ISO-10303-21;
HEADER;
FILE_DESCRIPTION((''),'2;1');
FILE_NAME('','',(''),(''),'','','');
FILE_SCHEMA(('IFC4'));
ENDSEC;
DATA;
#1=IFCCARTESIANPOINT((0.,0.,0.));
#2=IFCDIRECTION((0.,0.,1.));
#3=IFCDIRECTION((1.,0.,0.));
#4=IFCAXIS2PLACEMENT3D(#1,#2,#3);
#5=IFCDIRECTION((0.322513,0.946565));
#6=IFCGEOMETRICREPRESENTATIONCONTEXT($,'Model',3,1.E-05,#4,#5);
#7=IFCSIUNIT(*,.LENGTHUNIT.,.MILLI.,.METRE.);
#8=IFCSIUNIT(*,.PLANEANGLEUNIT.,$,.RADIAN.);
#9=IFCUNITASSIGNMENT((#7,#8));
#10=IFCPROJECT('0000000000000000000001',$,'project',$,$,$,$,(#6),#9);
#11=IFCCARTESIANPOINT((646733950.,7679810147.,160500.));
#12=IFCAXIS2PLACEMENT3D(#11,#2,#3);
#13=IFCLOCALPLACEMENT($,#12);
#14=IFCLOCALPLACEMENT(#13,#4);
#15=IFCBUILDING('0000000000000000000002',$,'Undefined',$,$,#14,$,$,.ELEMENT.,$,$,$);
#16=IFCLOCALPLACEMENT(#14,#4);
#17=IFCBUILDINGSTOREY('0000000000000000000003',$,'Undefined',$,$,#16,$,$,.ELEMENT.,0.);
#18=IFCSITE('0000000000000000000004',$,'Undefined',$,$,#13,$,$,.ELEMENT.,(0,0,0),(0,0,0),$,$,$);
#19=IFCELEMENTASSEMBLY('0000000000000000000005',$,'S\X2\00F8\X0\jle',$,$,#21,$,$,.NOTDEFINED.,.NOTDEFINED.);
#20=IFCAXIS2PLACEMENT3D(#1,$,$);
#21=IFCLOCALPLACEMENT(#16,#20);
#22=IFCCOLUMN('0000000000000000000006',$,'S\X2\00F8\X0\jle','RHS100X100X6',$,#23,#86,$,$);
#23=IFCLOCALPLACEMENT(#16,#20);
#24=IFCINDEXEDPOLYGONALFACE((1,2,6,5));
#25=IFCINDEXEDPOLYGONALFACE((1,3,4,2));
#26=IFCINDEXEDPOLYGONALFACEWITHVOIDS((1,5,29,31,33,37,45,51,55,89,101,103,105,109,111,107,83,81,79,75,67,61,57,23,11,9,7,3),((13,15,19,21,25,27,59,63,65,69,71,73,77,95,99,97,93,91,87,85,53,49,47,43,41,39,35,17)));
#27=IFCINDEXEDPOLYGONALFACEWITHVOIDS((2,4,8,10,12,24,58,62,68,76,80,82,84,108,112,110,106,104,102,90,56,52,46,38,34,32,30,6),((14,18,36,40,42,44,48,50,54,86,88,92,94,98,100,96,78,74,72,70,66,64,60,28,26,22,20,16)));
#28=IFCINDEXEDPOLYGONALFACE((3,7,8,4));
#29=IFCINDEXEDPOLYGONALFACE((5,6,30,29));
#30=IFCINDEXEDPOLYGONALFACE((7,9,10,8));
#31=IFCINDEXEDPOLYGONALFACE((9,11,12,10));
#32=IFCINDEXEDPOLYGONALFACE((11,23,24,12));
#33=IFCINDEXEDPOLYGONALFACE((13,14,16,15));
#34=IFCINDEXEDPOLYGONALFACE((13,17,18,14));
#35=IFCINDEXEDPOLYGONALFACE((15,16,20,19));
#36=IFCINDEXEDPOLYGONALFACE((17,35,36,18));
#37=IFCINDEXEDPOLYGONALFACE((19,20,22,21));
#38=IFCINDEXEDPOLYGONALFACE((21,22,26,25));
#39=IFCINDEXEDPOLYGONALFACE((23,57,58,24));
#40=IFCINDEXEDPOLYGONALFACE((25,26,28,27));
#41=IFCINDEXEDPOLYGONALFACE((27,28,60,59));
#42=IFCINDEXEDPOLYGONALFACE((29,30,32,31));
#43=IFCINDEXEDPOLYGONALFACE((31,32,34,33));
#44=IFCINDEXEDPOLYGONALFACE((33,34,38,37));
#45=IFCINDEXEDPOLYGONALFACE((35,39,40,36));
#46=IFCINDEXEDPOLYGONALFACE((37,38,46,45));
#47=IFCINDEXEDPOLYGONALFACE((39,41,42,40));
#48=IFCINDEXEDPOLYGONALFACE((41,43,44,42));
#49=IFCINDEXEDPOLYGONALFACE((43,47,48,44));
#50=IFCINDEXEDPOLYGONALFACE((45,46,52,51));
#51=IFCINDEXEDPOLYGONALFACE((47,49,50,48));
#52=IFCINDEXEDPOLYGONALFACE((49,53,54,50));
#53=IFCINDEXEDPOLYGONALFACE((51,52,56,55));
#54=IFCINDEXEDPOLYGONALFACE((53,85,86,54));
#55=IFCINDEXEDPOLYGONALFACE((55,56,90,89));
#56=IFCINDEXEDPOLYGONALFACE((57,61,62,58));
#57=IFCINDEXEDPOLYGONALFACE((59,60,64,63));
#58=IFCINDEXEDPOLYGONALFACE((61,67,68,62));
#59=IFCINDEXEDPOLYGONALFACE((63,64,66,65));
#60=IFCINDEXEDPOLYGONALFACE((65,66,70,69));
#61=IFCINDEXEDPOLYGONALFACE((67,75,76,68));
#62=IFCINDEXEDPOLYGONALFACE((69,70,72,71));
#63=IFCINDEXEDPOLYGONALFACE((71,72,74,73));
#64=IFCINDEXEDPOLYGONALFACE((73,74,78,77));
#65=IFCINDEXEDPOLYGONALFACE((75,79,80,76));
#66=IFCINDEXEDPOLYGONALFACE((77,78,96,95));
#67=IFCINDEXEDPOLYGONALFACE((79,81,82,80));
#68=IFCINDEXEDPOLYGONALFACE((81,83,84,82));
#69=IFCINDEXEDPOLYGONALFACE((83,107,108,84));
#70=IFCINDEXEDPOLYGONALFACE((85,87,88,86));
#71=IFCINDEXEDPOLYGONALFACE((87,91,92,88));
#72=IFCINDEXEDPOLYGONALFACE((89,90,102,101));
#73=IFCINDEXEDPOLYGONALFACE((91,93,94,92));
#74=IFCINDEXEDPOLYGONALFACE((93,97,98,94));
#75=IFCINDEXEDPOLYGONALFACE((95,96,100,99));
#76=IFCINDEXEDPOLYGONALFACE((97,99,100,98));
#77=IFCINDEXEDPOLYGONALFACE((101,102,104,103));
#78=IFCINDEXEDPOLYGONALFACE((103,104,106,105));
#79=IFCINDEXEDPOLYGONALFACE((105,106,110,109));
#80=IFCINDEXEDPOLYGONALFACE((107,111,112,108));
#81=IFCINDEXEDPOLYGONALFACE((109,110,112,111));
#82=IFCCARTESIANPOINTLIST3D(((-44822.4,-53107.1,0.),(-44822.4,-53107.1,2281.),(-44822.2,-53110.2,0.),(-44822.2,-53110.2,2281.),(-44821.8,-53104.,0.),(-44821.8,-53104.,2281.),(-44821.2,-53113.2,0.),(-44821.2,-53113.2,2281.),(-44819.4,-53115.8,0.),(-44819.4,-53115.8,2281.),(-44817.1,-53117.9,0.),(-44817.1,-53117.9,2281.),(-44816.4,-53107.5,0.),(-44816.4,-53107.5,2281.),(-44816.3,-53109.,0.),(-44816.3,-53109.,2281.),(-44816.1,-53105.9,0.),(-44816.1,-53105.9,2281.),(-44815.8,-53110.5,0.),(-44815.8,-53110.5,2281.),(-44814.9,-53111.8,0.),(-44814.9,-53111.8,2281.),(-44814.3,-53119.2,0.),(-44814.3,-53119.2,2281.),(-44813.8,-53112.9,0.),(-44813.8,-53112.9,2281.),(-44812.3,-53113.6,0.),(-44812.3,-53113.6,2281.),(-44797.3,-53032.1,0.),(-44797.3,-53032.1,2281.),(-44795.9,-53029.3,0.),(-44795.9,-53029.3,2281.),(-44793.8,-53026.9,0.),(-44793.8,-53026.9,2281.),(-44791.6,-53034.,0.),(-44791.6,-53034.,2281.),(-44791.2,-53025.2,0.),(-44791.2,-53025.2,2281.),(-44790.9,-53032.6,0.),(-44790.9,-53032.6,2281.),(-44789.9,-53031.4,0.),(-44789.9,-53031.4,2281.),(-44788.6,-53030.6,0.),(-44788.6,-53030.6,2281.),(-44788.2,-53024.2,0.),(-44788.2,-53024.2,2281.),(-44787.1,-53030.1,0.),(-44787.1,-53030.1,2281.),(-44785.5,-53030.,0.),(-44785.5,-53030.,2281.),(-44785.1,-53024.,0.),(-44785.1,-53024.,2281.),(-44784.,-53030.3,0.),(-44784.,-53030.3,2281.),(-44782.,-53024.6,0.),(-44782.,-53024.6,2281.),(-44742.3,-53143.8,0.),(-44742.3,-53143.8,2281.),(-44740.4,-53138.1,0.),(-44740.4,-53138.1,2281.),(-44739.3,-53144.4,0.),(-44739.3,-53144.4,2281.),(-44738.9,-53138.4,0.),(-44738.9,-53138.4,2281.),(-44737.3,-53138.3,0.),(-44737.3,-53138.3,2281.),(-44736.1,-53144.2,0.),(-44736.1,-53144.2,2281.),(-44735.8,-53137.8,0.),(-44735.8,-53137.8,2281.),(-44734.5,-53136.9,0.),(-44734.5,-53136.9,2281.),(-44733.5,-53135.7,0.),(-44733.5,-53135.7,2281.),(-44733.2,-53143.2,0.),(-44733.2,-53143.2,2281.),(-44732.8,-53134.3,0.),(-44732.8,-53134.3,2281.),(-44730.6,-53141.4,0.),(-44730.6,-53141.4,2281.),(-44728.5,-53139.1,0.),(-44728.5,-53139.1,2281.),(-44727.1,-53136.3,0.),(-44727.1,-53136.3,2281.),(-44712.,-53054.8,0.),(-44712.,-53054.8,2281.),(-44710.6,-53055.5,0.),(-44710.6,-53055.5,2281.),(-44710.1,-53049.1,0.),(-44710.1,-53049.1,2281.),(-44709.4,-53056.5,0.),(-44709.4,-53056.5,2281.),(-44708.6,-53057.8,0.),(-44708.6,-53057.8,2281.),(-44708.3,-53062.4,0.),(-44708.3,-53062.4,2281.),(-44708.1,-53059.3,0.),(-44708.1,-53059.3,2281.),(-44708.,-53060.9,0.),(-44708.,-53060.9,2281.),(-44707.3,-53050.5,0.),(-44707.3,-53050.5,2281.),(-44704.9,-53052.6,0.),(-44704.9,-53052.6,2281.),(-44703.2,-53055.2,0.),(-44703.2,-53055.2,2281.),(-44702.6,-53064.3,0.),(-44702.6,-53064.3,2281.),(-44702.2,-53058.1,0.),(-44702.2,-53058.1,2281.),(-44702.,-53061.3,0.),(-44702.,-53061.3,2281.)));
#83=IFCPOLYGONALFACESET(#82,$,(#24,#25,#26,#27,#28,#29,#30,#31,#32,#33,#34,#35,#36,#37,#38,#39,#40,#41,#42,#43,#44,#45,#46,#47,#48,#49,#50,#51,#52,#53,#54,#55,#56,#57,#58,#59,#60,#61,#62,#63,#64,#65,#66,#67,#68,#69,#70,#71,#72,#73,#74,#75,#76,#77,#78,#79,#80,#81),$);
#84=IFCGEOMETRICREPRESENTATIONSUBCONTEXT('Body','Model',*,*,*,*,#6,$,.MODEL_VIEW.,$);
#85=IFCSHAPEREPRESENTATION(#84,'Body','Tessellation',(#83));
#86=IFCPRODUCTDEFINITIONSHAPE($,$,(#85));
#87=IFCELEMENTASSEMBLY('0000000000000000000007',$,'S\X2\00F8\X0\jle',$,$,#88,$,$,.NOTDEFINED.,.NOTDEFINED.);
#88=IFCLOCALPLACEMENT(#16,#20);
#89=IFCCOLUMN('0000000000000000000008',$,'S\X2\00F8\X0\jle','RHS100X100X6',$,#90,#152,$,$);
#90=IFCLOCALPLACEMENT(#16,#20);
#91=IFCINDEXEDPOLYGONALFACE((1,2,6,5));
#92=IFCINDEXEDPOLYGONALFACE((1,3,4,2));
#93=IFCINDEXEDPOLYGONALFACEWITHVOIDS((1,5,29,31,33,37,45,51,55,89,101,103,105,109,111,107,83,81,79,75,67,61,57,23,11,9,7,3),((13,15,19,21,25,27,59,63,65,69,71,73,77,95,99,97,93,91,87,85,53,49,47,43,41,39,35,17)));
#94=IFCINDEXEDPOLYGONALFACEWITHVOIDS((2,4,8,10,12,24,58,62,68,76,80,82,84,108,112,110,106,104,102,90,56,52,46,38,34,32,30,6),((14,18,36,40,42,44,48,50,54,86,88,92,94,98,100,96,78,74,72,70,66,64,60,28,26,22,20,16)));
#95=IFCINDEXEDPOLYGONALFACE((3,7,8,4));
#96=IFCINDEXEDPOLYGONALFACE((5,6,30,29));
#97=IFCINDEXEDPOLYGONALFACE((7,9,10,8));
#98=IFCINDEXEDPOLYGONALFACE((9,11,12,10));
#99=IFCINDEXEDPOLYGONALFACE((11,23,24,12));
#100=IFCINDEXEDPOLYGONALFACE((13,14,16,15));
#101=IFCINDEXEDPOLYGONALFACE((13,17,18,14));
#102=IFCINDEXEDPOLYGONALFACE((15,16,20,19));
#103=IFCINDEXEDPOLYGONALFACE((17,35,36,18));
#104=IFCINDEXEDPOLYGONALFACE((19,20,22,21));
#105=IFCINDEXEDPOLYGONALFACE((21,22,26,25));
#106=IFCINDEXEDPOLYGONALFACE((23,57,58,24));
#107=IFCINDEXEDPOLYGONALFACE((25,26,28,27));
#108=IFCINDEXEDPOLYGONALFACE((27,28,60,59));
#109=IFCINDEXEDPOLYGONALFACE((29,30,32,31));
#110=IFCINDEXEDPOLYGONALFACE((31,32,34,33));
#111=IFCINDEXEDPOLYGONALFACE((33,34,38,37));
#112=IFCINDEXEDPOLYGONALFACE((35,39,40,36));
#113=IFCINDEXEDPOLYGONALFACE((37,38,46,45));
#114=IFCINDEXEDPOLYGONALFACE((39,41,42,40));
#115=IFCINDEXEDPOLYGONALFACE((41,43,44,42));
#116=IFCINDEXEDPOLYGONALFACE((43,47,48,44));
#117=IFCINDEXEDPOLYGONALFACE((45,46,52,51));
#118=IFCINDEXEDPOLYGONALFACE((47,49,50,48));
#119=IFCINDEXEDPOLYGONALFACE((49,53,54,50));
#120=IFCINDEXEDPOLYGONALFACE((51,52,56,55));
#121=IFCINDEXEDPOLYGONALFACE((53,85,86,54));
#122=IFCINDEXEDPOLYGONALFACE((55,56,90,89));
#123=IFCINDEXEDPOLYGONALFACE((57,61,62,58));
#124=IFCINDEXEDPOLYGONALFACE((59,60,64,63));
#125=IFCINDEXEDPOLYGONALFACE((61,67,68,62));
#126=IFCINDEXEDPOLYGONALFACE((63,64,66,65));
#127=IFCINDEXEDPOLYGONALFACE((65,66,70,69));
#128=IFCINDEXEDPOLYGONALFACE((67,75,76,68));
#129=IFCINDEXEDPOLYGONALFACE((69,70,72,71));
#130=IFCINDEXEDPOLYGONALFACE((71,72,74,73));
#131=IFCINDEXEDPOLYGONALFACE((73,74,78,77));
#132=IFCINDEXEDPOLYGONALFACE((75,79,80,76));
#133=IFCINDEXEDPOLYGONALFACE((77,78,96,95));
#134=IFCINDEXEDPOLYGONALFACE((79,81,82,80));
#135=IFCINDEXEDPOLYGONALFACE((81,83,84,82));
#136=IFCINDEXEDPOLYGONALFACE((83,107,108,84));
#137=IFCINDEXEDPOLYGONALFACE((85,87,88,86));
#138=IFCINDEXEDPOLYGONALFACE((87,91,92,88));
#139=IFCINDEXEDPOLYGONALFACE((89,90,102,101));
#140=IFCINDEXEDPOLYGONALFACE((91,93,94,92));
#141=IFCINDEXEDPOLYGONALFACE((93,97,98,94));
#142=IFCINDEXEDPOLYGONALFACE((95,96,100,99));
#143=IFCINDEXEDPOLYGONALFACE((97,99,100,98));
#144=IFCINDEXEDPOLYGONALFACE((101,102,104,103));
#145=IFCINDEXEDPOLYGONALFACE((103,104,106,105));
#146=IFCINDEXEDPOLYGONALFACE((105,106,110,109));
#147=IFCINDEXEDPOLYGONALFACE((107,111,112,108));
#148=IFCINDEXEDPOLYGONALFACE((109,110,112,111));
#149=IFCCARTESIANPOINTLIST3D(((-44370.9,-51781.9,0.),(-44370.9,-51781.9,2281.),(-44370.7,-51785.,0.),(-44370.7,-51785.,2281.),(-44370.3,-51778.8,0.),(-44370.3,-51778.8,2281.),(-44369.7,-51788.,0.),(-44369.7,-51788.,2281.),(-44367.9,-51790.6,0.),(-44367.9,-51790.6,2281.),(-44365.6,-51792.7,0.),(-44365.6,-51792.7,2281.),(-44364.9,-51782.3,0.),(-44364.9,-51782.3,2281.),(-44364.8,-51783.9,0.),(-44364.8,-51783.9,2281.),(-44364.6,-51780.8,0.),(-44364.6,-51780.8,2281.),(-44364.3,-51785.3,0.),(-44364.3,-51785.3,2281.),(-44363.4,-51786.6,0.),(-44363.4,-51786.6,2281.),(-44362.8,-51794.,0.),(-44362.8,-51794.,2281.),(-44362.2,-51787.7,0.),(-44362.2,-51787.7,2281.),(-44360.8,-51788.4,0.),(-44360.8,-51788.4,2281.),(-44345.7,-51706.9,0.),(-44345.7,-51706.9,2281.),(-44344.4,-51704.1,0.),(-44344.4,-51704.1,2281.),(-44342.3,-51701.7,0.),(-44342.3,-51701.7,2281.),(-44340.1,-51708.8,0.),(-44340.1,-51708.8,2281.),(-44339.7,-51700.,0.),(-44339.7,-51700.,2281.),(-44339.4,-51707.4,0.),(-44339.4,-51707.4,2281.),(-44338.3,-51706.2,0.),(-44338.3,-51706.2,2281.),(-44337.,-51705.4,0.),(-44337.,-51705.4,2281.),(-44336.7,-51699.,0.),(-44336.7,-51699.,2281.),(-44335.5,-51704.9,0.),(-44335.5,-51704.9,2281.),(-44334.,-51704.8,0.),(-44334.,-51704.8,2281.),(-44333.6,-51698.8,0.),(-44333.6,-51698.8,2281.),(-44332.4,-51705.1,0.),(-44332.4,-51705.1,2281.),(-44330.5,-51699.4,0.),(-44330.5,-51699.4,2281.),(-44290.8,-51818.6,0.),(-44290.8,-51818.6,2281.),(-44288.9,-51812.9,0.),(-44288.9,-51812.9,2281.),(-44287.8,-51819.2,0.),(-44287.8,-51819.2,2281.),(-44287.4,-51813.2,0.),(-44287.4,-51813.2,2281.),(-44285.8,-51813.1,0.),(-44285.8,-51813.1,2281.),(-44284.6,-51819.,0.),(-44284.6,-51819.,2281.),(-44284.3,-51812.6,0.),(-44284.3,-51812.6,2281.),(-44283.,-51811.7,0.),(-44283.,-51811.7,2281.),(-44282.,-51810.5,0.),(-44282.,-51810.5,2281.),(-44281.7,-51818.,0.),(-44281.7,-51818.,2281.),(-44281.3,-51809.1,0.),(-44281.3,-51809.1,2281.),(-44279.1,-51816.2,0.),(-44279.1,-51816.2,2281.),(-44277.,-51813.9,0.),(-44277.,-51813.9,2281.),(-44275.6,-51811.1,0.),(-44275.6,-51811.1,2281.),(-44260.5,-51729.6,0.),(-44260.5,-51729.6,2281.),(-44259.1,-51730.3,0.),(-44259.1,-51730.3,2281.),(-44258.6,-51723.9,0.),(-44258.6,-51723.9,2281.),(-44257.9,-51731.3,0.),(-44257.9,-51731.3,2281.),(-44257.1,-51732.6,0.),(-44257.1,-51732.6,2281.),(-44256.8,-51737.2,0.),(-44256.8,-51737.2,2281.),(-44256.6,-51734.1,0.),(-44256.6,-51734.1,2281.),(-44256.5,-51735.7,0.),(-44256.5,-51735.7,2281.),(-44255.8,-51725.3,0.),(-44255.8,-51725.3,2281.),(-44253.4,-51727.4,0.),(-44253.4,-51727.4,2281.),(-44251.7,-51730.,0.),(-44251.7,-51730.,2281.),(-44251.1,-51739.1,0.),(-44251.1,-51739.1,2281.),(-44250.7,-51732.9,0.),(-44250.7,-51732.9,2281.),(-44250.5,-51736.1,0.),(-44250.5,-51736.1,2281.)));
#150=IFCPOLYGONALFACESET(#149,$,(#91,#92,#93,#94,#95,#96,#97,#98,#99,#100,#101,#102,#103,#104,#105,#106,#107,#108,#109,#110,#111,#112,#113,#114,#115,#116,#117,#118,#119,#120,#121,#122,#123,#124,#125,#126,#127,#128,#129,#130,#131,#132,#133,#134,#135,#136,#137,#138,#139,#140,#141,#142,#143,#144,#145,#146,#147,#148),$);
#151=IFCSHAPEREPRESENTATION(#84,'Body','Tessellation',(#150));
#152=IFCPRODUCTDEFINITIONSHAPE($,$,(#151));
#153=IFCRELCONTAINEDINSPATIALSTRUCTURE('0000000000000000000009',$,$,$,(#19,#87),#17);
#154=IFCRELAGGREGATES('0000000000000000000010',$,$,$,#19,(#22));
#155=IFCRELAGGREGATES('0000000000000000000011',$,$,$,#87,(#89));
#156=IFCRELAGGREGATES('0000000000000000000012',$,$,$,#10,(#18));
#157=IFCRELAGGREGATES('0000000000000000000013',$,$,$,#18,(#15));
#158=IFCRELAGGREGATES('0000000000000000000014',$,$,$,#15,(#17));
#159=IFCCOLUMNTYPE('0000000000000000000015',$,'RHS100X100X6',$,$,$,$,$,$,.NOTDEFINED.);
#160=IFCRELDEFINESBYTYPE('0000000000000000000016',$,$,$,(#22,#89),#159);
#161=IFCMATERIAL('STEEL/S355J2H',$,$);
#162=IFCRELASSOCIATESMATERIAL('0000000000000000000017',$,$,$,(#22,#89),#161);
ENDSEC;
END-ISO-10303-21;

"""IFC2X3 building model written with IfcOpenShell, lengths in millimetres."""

from ifc_helpers import new_model, si_unit, direction, frame, origin_with_axes, origin_2d_with_axis, place, context, subcontext, project, spatial, hollow_rectangle, extrude, material, type_object, element, aggregate, save


model = new_model("IFC2X3")

# Units and contexts
model_context = context("Model", 3, precision=1e-05, world=origin_with_axes(), true_north=direction((0.322513, 0.946565)))
body_context = subcontext(model_context, "Body", "Model", "MODEL_VIEW")
ifc_project = project(units=[si_unit("LENGTHUNIT", "METRE", prefix="MILLI"), si_unit("PLANEANGLEUNIT", "RADIAN")], contexts=[model_context])

# Site, building, storey
site_placement = place(None, frame((646733950.0, 7679810147.0, 160500.0), z_axis=(0.0, 0.0, 1.0), x_axis=(1.0, 0.0, 0.0)))
site = spatial("IfcSite", under=ifc_project, at=site_placement, Name="Undefined", CompositionType="ELEMENT", RefLatitude=(0, 0, 0), RefLongitude=(0, 0, 0))
building_placement = place(site_placement, origin_with_axes())
building = spatial("IfcBuilding", under=site, at=building_placement, Name="Undefined", CompositionType="ELEMENT")
storey_placement = place(building_placement, origin_with_axes())
storey = spatial("IfcBuildingStorey", under=building, at=storey_placement, Name="Undefined", CompositionType="ELEMENT", Elevation=0.0)

# Element assemblies, columns
assembly_1_placement = place(storey_placement, origin_with_axes())
assembly_1 = element("IfcElementAssembly", 1, at=assembly_1_placement, inside=storey, Name="Søjle", AssemblyPlace="NOTDEFINED", PredefinedType="NOTDEFINED")
ifc_material_1 = material(Name="STEEL/S355J2H")
column_type = type_object("IfcColumnType", Name="RHS100X100X6", PredefinedType="NOTDEFINED")
column_1_placement = place(assembly_1_placement, frame((-44762.2, -53084.2, 0.0), z_axis=(0.0, 0.0, 1.0), x_axis=(0.322513, 0.946565, 0.0)))
column_1 = element("IfcColumn", 2, at=column_1_placement, type_object=column_type, material=ifc_material_1, Name="Søjle", Description="RHS100X100X6", context=body_context, shape_type="SweptSolid", body=[
    extrude(hollow_rectangle(XDim=100.0, YDim=100.0, WallThickness=6.0, InnerFilletRadius=6.0, OuterFilletRadius=12.0, at=origin_2d_with_axis()), frame((0.0, 0.0, 2281.0), z_axis=(0.0, 0.0, -1.0), x_axis=(0.0, 1.0, 0.0)), (0.0, 0.0, 1.0), 2281.0),
])
aggregate(assembly_1, [column_1])
assembly_2_placement = place(storey_placement, origin_with_axes())
assembly_2 = element("IfcElementAssembly", 3, at=assembly_2_placement, inside=storey, Name="Søjle", AssemblyPlace="NOTDEFINED", PredefinedType="NOTDEFINED")
column_2_placement = place(assembly_2_placement, frame((-44310.7, -51759.0, 0.0), z_axis=(0.0, 0.0, 1.0), x_axis=(0.322513, 0.946565, 0.0)))
column_2 = element("IfcColumn", 4, at=column_2_placement, type_object=column_type, material=ifc_material_1, Name="Søjle", Description="RHS100X100X6", context=body_context, shape_type="SweptSolid", body=[
    extrude(hollow_rectangle(XDim=100.0, YDim=100.0, WallThickness=6.0, InnerFilletRadius=6.0, OuterFilletRadius=12.0, at=origin_2d_with_axis()), frame((0.0, 0.0, 2281.0), z_axis=(0.0, 0.0, -1.0), x_axis=(0.0, 1.0, 0.0)), (0.0, 0.0, 1.0), 2281.0),
])
aggregate(assembly_2, [column_2])

save(model, "model.ifc")
